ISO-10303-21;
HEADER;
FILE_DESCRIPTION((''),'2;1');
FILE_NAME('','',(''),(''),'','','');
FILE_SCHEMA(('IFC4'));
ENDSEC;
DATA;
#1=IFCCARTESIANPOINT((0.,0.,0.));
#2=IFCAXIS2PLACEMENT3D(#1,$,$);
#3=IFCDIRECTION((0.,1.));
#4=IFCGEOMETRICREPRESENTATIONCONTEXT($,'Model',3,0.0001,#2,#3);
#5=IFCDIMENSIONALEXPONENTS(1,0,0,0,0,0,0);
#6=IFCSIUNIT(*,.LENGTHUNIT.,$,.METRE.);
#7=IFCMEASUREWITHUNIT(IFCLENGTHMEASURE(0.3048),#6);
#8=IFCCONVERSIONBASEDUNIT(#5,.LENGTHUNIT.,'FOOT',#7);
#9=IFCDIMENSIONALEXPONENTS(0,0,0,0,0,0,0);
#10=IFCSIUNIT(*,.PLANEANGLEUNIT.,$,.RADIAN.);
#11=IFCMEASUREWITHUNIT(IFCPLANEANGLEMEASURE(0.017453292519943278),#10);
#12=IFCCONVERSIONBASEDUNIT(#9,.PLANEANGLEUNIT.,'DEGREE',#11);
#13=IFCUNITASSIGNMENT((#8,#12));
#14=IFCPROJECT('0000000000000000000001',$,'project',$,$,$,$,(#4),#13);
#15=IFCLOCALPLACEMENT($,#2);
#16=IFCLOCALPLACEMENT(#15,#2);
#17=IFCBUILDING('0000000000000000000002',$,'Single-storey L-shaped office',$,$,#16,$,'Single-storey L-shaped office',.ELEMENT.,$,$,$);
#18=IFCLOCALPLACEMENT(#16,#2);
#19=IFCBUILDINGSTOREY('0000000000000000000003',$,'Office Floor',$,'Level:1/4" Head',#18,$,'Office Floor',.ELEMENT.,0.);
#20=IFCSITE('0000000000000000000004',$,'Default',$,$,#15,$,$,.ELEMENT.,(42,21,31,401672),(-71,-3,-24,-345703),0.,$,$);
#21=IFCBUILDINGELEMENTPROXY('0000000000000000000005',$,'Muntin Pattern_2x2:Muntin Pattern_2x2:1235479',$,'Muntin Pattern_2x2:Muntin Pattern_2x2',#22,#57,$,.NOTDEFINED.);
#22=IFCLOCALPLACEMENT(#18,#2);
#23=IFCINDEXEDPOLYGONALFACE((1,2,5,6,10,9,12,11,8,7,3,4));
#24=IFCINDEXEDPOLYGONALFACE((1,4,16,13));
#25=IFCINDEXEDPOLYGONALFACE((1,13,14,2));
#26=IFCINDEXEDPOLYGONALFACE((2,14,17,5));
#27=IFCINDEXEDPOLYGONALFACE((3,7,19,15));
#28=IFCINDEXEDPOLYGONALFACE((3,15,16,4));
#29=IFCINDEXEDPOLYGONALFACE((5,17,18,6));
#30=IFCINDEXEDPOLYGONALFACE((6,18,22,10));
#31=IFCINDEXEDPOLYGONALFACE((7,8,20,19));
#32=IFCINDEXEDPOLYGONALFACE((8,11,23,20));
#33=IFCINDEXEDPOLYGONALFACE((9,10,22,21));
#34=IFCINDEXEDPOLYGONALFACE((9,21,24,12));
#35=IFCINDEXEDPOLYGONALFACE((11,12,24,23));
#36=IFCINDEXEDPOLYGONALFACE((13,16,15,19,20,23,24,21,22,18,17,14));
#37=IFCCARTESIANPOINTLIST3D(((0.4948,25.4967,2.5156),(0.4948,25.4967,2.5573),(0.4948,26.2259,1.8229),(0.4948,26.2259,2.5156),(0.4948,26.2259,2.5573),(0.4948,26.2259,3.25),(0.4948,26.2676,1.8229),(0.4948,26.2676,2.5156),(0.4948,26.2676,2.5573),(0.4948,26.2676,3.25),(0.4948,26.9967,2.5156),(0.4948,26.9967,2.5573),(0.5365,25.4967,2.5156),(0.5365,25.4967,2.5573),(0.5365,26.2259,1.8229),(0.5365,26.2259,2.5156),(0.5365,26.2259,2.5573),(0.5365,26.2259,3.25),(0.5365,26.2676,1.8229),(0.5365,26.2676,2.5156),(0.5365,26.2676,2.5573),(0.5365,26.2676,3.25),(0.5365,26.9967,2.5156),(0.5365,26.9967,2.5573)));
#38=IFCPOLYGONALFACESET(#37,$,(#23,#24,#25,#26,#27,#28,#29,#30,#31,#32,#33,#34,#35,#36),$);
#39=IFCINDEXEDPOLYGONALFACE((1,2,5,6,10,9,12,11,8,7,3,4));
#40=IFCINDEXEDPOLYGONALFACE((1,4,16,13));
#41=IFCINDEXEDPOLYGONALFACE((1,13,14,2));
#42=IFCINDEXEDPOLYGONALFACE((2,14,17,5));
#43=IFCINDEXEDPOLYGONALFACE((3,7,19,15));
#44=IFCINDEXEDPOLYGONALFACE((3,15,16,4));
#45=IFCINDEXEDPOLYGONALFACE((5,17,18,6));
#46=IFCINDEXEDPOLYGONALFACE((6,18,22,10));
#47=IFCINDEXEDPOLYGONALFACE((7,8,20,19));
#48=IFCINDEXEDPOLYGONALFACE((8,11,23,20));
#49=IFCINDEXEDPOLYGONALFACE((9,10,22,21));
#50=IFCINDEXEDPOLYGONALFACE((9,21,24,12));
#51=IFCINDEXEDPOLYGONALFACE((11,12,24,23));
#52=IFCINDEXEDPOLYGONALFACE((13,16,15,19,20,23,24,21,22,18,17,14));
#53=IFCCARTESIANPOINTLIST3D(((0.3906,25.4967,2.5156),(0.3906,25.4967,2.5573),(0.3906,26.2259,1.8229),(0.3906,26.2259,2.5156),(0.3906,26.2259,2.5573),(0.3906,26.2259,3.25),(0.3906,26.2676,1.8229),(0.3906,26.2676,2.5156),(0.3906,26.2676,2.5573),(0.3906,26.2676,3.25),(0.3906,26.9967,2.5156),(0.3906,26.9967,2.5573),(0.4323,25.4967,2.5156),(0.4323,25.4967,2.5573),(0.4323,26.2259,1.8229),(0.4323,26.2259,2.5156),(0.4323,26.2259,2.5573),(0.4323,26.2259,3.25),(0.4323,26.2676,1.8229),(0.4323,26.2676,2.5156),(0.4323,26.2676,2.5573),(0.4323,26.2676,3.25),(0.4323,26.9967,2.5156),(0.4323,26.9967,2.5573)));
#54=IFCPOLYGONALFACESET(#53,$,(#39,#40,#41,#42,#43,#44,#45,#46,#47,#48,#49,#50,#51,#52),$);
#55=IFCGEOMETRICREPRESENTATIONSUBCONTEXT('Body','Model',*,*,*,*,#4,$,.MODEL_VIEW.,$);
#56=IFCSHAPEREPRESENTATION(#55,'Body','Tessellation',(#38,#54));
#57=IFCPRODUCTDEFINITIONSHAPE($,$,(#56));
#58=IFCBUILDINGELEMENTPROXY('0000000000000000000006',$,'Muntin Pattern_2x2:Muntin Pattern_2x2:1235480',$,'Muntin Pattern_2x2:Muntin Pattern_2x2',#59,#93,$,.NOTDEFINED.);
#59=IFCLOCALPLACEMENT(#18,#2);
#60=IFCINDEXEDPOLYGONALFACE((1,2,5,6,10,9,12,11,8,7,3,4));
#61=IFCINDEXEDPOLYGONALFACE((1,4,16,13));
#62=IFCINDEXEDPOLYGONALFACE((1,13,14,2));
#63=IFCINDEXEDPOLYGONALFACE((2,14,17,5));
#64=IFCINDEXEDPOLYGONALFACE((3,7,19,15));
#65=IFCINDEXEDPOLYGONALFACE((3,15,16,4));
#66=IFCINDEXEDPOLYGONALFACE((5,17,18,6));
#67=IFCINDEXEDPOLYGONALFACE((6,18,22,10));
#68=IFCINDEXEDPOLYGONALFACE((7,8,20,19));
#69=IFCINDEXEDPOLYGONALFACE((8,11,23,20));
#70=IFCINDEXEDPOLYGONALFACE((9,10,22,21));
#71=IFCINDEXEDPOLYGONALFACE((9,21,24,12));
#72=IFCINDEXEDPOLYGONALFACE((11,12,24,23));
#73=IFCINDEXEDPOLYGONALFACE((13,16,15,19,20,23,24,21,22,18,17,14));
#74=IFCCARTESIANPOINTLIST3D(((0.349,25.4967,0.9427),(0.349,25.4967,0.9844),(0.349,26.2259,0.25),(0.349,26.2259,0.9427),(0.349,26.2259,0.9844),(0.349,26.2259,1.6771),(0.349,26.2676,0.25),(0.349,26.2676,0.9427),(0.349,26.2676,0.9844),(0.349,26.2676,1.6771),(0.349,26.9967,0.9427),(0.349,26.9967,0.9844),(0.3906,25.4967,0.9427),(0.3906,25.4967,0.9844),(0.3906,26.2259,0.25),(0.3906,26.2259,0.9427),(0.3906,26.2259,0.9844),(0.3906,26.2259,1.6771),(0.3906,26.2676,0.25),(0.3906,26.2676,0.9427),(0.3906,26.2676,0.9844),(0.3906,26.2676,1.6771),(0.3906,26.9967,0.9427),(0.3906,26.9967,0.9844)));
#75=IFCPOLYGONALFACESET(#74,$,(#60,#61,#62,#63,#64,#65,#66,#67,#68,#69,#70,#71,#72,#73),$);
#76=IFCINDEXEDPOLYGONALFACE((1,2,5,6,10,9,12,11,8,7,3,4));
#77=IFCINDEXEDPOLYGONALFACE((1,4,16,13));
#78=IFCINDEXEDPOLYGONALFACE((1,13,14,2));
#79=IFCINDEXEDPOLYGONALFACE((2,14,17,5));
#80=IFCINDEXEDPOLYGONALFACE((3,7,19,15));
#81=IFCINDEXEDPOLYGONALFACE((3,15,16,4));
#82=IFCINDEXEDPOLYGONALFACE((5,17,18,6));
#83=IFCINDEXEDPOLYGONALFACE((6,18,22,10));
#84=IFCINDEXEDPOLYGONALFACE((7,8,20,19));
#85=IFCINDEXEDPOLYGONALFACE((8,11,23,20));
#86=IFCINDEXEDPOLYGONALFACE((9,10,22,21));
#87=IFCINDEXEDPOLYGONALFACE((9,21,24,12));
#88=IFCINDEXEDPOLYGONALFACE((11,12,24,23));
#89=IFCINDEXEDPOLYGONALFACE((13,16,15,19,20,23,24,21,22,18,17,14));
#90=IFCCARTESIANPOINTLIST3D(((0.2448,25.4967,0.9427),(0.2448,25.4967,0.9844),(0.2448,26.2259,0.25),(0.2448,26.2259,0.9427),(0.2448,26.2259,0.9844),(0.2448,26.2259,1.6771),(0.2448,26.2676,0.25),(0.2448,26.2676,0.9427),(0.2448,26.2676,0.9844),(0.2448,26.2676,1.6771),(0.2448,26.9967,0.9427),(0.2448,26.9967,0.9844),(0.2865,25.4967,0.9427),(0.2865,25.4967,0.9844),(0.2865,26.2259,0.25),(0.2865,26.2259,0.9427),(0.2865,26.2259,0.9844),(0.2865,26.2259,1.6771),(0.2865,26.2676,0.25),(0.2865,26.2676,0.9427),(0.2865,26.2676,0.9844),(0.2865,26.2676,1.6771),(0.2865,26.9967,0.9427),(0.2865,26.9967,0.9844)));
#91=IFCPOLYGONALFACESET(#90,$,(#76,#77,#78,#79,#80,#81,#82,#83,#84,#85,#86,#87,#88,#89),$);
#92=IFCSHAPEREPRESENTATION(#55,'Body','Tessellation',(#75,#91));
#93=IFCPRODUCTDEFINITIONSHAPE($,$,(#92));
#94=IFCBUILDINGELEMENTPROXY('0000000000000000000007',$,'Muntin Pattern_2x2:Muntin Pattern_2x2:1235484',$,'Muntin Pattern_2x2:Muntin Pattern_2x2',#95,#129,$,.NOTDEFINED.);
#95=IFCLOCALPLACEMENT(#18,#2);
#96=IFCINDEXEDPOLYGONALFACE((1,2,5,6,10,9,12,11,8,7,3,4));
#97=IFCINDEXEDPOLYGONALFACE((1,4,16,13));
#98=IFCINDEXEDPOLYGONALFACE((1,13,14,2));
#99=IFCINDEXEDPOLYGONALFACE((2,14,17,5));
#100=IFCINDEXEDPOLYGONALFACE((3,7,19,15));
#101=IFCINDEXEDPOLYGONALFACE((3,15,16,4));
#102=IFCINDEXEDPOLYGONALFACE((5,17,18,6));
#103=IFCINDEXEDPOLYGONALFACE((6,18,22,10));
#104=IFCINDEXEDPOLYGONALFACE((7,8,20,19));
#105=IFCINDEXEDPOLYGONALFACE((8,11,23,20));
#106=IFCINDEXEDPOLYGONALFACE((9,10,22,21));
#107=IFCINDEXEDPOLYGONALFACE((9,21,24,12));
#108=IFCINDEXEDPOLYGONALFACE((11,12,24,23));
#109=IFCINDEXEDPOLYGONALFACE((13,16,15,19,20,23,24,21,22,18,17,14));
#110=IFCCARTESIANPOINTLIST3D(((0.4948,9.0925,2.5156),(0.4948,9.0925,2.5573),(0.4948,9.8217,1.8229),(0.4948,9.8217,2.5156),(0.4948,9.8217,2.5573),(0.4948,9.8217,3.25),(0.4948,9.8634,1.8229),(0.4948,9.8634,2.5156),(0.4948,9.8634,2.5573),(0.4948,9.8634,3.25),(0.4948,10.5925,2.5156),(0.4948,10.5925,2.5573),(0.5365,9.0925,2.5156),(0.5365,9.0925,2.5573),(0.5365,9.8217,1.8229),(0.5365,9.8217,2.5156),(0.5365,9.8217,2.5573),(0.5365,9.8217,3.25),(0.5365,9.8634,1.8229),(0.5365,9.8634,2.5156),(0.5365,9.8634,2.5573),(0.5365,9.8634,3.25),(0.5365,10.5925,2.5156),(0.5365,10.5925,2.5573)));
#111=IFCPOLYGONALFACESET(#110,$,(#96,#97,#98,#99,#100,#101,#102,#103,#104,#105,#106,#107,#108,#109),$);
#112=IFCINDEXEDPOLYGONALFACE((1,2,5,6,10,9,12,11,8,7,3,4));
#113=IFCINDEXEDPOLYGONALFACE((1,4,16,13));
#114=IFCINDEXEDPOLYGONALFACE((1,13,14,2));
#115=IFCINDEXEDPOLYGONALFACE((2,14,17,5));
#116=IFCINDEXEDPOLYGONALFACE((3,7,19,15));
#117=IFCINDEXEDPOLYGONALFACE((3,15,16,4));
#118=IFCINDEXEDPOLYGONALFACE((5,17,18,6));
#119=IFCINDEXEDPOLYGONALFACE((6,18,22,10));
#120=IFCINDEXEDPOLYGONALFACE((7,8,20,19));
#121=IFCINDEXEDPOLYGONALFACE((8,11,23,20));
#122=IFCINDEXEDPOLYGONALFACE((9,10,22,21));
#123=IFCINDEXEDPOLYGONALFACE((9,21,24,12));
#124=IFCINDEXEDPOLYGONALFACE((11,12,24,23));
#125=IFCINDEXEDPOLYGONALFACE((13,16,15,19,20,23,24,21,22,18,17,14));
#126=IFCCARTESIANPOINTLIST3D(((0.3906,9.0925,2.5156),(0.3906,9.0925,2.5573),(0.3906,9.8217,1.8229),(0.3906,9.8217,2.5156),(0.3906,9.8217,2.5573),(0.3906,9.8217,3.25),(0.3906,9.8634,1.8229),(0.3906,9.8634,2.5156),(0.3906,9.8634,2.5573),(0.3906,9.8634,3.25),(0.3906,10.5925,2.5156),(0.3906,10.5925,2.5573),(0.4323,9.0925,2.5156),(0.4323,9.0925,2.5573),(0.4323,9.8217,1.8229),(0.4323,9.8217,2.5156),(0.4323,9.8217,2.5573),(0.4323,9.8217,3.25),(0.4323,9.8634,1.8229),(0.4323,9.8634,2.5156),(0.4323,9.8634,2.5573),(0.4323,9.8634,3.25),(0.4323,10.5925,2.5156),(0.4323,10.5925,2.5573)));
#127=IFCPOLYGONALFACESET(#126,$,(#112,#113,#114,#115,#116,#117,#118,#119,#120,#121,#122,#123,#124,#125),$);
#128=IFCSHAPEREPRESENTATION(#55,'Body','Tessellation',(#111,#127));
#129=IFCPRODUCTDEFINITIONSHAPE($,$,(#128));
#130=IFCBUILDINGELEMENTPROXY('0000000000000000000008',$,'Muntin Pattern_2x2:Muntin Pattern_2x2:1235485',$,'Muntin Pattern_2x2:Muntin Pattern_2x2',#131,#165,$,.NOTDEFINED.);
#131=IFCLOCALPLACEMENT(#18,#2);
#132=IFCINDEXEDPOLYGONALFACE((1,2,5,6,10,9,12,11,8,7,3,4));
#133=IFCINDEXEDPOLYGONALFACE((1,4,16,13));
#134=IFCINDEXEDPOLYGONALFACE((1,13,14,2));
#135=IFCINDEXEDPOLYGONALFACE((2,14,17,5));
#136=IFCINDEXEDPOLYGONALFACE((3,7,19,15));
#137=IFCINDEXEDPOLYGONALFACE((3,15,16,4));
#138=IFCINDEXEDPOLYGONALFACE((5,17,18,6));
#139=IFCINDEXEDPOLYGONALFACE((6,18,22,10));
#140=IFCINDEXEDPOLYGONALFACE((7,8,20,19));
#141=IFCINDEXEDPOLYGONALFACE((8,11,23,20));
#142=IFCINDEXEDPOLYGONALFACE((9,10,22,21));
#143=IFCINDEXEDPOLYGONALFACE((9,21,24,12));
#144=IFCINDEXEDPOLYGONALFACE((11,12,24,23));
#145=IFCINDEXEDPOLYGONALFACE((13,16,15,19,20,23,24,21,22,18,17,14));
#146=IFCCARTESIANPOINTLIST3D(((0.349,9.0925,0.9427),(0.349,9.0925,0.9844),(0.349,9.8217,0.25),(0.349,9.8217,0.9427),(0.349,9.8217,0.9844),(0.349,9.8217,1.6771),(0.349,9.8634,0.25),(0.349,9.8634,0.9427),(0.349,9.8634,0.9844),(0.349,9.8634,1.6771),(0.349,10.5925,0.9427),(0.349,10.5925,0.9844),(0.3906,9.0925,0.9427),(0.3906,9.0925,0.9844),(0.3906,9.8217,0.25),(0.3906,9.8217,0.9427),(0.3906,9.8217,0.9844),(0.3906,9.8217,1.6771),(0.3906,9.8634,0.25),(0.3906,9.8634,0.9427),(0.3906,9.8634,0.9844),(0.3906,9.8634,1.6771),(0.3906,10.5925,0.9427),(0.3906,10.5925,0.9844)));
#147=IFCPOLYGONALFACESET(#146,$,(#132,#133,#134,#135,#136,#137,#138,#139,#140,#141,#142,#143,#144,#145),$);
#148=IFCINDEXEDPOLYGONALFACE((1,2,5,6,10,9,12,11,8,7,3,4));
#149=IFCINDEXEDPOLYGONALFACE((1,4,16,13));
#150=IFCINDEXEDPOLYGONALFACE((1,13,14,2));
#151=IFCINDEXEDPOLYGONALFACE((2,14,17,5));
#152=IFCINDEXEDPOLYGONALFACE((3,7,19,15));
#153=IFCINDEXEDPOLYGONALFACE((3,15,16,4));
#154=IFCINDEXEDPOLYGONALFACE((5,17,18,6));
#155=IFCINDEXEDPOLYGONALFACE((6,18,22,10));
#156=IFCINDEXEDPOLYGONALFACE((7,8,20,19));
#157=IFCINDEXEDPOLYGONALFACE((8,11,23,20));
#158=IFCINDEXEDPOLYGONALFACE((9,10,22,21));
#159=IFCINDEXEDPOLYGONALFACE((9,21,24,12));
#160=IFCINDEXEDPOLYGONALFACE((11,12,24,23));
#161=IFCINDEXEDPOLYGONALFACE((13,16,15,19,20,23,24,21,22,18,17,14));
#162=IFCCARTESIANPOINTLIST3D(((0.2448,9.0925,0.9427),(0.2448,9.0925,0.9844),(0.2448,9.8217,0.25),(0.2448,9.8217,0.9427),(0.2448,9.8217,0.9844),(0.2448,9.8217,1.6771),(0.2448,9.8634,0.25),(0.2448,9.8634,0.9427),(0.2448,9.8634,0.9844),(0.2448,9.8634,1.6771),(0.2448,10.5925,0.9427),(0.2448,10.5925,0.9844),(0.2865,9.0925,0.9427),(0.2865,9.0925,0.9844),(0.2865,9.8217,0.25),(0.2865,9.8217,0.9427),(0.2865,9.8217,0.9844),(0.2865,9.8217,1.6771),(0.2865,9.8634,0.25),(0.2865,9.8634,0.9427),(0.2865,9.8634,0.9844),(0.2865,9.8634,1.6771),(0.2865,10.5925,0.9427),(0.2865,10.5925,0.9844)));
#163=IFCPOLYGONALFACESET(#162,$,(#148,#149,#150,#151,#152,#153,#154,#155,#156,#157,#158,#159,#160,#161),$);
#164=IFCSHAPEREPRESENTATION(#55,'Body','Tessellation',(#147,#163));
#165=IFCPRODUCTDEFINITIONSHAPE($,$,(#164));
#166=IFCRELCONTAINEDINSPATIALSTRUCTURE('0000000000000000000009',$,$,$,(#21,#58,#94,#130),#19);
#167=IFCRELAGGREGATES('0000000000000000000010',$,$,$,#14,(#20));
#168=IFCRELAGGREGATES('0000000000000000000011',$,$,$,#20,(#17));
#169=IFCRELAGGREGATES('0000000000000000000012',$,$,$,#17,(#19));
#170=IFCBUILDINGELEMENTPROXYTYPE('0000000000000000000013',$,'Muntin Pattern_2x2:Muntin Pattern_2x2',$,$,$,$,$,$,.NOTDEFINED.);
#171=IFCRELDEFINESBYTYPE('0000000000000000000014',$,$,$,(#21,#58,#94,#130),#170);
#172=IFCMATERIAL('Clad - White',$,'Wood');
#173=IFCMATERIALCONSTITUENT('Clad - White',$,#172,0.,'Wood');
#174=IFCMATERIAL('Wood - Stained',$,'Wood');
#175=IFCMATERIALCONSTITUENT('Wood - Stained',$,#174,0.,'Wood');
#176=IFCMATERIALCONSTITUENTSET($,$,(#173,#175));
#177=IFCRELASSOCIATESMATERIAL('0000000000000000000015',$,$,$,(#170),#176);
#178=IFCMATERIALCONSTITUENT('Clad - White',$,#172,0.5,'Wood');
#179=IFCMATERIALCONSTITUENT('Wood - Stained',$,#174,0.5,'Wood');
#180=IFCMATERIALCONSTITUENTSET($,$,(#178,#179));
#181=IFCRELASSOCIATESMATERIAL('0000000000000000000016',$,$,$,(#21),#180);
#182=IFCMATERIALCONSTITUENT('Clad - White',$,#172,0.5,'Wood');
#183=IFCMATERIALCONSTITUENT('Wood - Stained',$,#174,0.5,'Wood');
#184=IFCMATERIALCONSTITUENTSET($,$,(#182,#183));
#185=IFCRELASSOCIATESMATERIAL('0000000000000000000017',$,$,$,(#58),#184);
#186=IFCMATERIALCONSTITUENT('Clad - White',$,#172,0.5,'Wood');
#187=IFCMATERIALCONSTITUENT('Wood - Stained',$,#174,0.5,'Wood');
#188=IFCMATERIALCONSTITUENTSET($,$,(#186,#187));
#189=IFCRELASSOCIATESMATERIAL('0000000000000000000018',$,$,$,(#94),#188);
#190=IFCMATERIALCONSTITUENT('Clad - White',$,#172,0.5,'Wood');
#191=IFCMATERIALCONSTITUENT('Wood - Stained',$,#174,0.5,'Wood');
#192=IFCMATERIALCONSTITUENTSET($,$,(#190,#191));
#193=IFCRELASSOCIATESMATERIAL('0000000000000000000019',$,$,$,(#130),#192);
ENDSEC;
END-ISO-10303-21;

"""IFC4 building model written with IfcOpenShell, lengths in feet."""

from ifc_helpers import new_model, entity, si_unit, converted_unit, direction, frame, origin, place, context, subcontext, project, spatial, indexed_curve, outline, extrude, source, transform, mapped, material, constituent, constituent_set, type_object, type_shapes, element, save


model = new_model("IFC4")

# Units and contexts
model_context = context("Model", 3, precision=0.0001, world=origin(), true_north=direction((0.0, 1.0)))
body_context = subcontext(model_context, "Body", "Model", "MODEL_VIEW")
ifc_project = project(units=[converted_unit("LENGTHUNIT", "FOOT", entity("IfcLengthMeasure", 0.3048), si_unit("LENGTHUNIT", "METRE"), dimensions=[1, 0, 0, 0, 0, 0, 0]), converted_unit("PLANEANGLEUNIT", "DEGREE", entity("IfcPlaneAngleMeasure", 0.017453292519943278), si_unit("PLANEANGLEUNIT", "RADIAN"), dimensions=[0, 0, 0, 0, 0, 0, 0])], contexts=[model_context])

# Site, building, storey
site_placement = place(None, origin())
site = spatial("IfcSite", under=ifc_project, at=site_placement, Name="Default", CompositionType="ELEMENT", RefLatitude=(42, 21, 31, 401672), RefLongitude=(-71, -3, -24, -345703), RefElevation=0.0)
building_placement = place(site_placement, origin())
building = spatial("IfcBuilding", under=site, at=building_placement, Name="Single-storey L-shaped office", LongName="Single-storey L-shaped office", CompositionType="ELEMENT")
storey_placement = place(building_placement, origin())
storey = spatial("IfcBuildingStorey", under=building, at=storey_placement, Name="Office Floor", ObjectType="Level:1/4\" Head", LongName="Office Floor", CompositionType="ELEMENT", Elevation=0.0)

# Shared definitions
ifc_material_1 = material(Name="Wood - Stained", Category="Wood")

# Building element proxies
ifc_material_2 = material(Name="Clad - White", Category="Wood")
ifc_constituent_1 = constituent(ifc_material_2, Name="Clad - White", Category="Wood", fraction=0.0)
ifc_constituent_2 = constituent(ifc_material_1, Name="Wood - Stained", Category="Wood", fraction=0.0)
ifc_constituent_set_1 = constituent_set(constituents=[ifc_constituent_1, ifc_constituent_2])
building_element_proxy_type_1 = type_object("IfcBuildingElementProxyType", Name="Muntin Pattern_2x2:Muntin Pattern_2x2", PredefinedType="NOTDEFINED", material=ifc_constituent_set_1)
shared_shape_1 = source(origin(), body_context, "Body", "SweptSolid", [
    extrude(outline(indexed_curve([(0.0208, -0.0208), (0.7135, -0.0208), (0.7135, 0.0208), (0.0208, 0.0208), (0.0208, 0.75), (-0.0208, 0.75), (-0.0208, 0.0208), (-0.7135, 0.0208), (-0.7135, -0.0208), (-0.0208, -0.0208), (-0.0208, -0.75), (0.0208, -0.75), (0.0208, -0.0208)], self_intersect=False)), frame((0.0, 0.0312, 0.7135), z_axis=(0.0, 1.0, 0.0), x_axis=(0.0, 0.0, 1.0)), (0.0, 0.0, 1.0), 0.0417),
    extrude(outline(indexed_curve([(0.0208, -0.0208), (0.7135, -0.0208), (0.7135, 0.0208), (0.0208, 0.0208), (0.0208, 0.75), (-0.0208, 0.75), (-0.0208, 0.0208), (-0.7135, 0.0208), (-0.7135, -0.0208), (-0.0208, -0.0208), (-0.0208, -0.75), (0.0208, -0.75), (0.0208, -0.0208)], self_intersect=False)), frame((0.0, -0.0729, 0.7135), z_axis=(0.0, 1.0, 0.0), x_axis=(0.0, 0.0, 1.0)), (0.0, 0.0, 1.0), 0.0417),
])
type_shapes(building_element_proxy_type_1, [shared_shape_1])
ifc_constituent_3 = constituent(ifc_material_2, Name="Clad - White", Category="Wood", fraction=0.5)
ifc_constituent_4 = constituent(ifc_material_1, Name="Wood - Stained", Category="Wood", fraction=0.5)
ifc_constituent_set_2 = constituent_set(constituents=[ifc_constituent_3, ifc_constituent_4])
proxy_1_placement = place(storey_placement, frame((0.4635, 26.2467, 1.8229), z_axis=(0.0, 0.0, 1.0), x_axis=(0.0, -1.0, 0.0)))
element("IfcBuildingElementProxy", 1, at=proxy_1_placement, inside=storey, type_object=building_element_proxy_type_1, material=ifc_constituent_set_2, Name="Muntin Pattern_2x2:Muntin Pattern_2x2:1235479", ObjectType="Muntin Pattern_2x2:Muntin Pattern_2x2", PredefinedType="NOTDEFINED", context=body_context, shape_type="MappedRepresentation", body=[
    mapped(shared_shape_1, transform((0.0, 0.0, 0.0), scale=1.0)),
])
ifc_constituent_5 = constituent(ifc_material_2, Name="Clad - White", Category="Wood", fraction=0.5)
ifc_constituent_6 = constituent(ifc_material_1, Name="Wood - Stained", Category="Wood", fraction=0.5)
ifc_constituent_set_3 = constituent_set(constituents=[ifc_constituent_5, ifc_constituent_6])
proxy_2_placement = place(storey_placement, frame((0.3177, 26.2467, 0.25), z_axis=(0.0, 0.0, 1.0), x_axis=(0.0, -1.0, 0.0)))
element("IfcBuildingElementProxy", 2, at=proxy_2_placement, inside=storey, type_object=building_element_proxy_type_1, material=ifc_constituent_set_3, Name="Muntin Pattern_2x2:Muntin Pattern_2x2:1235480", ObjectType="Muntin Pattern_2x2:Muntin Pattern_2x2", PredefinedType="NOTDEFINED", context=body_context, shape_type="MappedRepresentation", body=[
    mapped(shared_shape_1, transform((0.0, 0.0, 0.0), scale=1.0)),
])
ifc_constituent_7 = constituent(ifc_material_2, Name="Clad - White", Category="Wood", fraction=0.5)
ifc_constituent_8 = constituent(ifc_material_1, Name="Wood - Stained", Category="Wood", fraction=0.5)
ifc_constituent_set_4 = constituent_set(constituents=[ifc_constituent_7, ifc_constituent_8])
proxy_3_placement = place(storey_placement, frame((0.4635, 9.8425, 1.8229), z_axis=(0.0, 0.0, 1.0), x_axis=(0.0, -1.0, 0.0)))
element("IfcBuildingElementProxy", 3, at=proxy_3_placement, inside=storey, type_object=building_element_proxy_type_1, material=ifc_constituent_set_4, Name="Muntin Pattern_2x2:Muntin Pattern_2x2:1235484", ObjectType="Muntin Pattern_2x2:Muntin Pattern_2x2", PredefinedType="NOTDEFINED", context=body_context, shape_type="MappedRepresentation", body=[
    mapped(shared_shape_1, transform((0.0, 0.0, 0.0), scale=1.0)),
])
ifc_constituent_9 = constituent(ifc_material_2, Name="Clad - White", Category="Wood", fraction=0.5)
ifc_constituent_10 = constituent(ifc_material_1, Name="Wood - Stained", Category="Wood", fraction=0.5)
ifc_constituent_set_5 = constituent_set(constituents=[ifc_constituent_9, ifc_constituent_10])
proxy_4_placement = place(storey_placement, frame((0.3177, 9.8425, 0.25), z_axis=(0.0, 0.0, 1.0), x_axis=(0.0, -1.0, 0.0)))
element("IfcBuildingElementProxy", 4, at=proxy_4_placement, inside=storey, type_object=building_element_proxy_type_1, material=ifc_constituent_set_5, Name="Muntin Pattern_2x2:Muntin Pattern_2x2:1235485", ObjectType="Muntin Pattern_2x2:Muntin Pattern_2x2", PredefinedType="NOTDEFINED", context=body_context, shape_type="MappedRepresentation", body=[
    mapped(shared_shape_1, transform((0.0, 0.0, 0.0), scale=1.0)),
])

save(model, "model.ifc")
